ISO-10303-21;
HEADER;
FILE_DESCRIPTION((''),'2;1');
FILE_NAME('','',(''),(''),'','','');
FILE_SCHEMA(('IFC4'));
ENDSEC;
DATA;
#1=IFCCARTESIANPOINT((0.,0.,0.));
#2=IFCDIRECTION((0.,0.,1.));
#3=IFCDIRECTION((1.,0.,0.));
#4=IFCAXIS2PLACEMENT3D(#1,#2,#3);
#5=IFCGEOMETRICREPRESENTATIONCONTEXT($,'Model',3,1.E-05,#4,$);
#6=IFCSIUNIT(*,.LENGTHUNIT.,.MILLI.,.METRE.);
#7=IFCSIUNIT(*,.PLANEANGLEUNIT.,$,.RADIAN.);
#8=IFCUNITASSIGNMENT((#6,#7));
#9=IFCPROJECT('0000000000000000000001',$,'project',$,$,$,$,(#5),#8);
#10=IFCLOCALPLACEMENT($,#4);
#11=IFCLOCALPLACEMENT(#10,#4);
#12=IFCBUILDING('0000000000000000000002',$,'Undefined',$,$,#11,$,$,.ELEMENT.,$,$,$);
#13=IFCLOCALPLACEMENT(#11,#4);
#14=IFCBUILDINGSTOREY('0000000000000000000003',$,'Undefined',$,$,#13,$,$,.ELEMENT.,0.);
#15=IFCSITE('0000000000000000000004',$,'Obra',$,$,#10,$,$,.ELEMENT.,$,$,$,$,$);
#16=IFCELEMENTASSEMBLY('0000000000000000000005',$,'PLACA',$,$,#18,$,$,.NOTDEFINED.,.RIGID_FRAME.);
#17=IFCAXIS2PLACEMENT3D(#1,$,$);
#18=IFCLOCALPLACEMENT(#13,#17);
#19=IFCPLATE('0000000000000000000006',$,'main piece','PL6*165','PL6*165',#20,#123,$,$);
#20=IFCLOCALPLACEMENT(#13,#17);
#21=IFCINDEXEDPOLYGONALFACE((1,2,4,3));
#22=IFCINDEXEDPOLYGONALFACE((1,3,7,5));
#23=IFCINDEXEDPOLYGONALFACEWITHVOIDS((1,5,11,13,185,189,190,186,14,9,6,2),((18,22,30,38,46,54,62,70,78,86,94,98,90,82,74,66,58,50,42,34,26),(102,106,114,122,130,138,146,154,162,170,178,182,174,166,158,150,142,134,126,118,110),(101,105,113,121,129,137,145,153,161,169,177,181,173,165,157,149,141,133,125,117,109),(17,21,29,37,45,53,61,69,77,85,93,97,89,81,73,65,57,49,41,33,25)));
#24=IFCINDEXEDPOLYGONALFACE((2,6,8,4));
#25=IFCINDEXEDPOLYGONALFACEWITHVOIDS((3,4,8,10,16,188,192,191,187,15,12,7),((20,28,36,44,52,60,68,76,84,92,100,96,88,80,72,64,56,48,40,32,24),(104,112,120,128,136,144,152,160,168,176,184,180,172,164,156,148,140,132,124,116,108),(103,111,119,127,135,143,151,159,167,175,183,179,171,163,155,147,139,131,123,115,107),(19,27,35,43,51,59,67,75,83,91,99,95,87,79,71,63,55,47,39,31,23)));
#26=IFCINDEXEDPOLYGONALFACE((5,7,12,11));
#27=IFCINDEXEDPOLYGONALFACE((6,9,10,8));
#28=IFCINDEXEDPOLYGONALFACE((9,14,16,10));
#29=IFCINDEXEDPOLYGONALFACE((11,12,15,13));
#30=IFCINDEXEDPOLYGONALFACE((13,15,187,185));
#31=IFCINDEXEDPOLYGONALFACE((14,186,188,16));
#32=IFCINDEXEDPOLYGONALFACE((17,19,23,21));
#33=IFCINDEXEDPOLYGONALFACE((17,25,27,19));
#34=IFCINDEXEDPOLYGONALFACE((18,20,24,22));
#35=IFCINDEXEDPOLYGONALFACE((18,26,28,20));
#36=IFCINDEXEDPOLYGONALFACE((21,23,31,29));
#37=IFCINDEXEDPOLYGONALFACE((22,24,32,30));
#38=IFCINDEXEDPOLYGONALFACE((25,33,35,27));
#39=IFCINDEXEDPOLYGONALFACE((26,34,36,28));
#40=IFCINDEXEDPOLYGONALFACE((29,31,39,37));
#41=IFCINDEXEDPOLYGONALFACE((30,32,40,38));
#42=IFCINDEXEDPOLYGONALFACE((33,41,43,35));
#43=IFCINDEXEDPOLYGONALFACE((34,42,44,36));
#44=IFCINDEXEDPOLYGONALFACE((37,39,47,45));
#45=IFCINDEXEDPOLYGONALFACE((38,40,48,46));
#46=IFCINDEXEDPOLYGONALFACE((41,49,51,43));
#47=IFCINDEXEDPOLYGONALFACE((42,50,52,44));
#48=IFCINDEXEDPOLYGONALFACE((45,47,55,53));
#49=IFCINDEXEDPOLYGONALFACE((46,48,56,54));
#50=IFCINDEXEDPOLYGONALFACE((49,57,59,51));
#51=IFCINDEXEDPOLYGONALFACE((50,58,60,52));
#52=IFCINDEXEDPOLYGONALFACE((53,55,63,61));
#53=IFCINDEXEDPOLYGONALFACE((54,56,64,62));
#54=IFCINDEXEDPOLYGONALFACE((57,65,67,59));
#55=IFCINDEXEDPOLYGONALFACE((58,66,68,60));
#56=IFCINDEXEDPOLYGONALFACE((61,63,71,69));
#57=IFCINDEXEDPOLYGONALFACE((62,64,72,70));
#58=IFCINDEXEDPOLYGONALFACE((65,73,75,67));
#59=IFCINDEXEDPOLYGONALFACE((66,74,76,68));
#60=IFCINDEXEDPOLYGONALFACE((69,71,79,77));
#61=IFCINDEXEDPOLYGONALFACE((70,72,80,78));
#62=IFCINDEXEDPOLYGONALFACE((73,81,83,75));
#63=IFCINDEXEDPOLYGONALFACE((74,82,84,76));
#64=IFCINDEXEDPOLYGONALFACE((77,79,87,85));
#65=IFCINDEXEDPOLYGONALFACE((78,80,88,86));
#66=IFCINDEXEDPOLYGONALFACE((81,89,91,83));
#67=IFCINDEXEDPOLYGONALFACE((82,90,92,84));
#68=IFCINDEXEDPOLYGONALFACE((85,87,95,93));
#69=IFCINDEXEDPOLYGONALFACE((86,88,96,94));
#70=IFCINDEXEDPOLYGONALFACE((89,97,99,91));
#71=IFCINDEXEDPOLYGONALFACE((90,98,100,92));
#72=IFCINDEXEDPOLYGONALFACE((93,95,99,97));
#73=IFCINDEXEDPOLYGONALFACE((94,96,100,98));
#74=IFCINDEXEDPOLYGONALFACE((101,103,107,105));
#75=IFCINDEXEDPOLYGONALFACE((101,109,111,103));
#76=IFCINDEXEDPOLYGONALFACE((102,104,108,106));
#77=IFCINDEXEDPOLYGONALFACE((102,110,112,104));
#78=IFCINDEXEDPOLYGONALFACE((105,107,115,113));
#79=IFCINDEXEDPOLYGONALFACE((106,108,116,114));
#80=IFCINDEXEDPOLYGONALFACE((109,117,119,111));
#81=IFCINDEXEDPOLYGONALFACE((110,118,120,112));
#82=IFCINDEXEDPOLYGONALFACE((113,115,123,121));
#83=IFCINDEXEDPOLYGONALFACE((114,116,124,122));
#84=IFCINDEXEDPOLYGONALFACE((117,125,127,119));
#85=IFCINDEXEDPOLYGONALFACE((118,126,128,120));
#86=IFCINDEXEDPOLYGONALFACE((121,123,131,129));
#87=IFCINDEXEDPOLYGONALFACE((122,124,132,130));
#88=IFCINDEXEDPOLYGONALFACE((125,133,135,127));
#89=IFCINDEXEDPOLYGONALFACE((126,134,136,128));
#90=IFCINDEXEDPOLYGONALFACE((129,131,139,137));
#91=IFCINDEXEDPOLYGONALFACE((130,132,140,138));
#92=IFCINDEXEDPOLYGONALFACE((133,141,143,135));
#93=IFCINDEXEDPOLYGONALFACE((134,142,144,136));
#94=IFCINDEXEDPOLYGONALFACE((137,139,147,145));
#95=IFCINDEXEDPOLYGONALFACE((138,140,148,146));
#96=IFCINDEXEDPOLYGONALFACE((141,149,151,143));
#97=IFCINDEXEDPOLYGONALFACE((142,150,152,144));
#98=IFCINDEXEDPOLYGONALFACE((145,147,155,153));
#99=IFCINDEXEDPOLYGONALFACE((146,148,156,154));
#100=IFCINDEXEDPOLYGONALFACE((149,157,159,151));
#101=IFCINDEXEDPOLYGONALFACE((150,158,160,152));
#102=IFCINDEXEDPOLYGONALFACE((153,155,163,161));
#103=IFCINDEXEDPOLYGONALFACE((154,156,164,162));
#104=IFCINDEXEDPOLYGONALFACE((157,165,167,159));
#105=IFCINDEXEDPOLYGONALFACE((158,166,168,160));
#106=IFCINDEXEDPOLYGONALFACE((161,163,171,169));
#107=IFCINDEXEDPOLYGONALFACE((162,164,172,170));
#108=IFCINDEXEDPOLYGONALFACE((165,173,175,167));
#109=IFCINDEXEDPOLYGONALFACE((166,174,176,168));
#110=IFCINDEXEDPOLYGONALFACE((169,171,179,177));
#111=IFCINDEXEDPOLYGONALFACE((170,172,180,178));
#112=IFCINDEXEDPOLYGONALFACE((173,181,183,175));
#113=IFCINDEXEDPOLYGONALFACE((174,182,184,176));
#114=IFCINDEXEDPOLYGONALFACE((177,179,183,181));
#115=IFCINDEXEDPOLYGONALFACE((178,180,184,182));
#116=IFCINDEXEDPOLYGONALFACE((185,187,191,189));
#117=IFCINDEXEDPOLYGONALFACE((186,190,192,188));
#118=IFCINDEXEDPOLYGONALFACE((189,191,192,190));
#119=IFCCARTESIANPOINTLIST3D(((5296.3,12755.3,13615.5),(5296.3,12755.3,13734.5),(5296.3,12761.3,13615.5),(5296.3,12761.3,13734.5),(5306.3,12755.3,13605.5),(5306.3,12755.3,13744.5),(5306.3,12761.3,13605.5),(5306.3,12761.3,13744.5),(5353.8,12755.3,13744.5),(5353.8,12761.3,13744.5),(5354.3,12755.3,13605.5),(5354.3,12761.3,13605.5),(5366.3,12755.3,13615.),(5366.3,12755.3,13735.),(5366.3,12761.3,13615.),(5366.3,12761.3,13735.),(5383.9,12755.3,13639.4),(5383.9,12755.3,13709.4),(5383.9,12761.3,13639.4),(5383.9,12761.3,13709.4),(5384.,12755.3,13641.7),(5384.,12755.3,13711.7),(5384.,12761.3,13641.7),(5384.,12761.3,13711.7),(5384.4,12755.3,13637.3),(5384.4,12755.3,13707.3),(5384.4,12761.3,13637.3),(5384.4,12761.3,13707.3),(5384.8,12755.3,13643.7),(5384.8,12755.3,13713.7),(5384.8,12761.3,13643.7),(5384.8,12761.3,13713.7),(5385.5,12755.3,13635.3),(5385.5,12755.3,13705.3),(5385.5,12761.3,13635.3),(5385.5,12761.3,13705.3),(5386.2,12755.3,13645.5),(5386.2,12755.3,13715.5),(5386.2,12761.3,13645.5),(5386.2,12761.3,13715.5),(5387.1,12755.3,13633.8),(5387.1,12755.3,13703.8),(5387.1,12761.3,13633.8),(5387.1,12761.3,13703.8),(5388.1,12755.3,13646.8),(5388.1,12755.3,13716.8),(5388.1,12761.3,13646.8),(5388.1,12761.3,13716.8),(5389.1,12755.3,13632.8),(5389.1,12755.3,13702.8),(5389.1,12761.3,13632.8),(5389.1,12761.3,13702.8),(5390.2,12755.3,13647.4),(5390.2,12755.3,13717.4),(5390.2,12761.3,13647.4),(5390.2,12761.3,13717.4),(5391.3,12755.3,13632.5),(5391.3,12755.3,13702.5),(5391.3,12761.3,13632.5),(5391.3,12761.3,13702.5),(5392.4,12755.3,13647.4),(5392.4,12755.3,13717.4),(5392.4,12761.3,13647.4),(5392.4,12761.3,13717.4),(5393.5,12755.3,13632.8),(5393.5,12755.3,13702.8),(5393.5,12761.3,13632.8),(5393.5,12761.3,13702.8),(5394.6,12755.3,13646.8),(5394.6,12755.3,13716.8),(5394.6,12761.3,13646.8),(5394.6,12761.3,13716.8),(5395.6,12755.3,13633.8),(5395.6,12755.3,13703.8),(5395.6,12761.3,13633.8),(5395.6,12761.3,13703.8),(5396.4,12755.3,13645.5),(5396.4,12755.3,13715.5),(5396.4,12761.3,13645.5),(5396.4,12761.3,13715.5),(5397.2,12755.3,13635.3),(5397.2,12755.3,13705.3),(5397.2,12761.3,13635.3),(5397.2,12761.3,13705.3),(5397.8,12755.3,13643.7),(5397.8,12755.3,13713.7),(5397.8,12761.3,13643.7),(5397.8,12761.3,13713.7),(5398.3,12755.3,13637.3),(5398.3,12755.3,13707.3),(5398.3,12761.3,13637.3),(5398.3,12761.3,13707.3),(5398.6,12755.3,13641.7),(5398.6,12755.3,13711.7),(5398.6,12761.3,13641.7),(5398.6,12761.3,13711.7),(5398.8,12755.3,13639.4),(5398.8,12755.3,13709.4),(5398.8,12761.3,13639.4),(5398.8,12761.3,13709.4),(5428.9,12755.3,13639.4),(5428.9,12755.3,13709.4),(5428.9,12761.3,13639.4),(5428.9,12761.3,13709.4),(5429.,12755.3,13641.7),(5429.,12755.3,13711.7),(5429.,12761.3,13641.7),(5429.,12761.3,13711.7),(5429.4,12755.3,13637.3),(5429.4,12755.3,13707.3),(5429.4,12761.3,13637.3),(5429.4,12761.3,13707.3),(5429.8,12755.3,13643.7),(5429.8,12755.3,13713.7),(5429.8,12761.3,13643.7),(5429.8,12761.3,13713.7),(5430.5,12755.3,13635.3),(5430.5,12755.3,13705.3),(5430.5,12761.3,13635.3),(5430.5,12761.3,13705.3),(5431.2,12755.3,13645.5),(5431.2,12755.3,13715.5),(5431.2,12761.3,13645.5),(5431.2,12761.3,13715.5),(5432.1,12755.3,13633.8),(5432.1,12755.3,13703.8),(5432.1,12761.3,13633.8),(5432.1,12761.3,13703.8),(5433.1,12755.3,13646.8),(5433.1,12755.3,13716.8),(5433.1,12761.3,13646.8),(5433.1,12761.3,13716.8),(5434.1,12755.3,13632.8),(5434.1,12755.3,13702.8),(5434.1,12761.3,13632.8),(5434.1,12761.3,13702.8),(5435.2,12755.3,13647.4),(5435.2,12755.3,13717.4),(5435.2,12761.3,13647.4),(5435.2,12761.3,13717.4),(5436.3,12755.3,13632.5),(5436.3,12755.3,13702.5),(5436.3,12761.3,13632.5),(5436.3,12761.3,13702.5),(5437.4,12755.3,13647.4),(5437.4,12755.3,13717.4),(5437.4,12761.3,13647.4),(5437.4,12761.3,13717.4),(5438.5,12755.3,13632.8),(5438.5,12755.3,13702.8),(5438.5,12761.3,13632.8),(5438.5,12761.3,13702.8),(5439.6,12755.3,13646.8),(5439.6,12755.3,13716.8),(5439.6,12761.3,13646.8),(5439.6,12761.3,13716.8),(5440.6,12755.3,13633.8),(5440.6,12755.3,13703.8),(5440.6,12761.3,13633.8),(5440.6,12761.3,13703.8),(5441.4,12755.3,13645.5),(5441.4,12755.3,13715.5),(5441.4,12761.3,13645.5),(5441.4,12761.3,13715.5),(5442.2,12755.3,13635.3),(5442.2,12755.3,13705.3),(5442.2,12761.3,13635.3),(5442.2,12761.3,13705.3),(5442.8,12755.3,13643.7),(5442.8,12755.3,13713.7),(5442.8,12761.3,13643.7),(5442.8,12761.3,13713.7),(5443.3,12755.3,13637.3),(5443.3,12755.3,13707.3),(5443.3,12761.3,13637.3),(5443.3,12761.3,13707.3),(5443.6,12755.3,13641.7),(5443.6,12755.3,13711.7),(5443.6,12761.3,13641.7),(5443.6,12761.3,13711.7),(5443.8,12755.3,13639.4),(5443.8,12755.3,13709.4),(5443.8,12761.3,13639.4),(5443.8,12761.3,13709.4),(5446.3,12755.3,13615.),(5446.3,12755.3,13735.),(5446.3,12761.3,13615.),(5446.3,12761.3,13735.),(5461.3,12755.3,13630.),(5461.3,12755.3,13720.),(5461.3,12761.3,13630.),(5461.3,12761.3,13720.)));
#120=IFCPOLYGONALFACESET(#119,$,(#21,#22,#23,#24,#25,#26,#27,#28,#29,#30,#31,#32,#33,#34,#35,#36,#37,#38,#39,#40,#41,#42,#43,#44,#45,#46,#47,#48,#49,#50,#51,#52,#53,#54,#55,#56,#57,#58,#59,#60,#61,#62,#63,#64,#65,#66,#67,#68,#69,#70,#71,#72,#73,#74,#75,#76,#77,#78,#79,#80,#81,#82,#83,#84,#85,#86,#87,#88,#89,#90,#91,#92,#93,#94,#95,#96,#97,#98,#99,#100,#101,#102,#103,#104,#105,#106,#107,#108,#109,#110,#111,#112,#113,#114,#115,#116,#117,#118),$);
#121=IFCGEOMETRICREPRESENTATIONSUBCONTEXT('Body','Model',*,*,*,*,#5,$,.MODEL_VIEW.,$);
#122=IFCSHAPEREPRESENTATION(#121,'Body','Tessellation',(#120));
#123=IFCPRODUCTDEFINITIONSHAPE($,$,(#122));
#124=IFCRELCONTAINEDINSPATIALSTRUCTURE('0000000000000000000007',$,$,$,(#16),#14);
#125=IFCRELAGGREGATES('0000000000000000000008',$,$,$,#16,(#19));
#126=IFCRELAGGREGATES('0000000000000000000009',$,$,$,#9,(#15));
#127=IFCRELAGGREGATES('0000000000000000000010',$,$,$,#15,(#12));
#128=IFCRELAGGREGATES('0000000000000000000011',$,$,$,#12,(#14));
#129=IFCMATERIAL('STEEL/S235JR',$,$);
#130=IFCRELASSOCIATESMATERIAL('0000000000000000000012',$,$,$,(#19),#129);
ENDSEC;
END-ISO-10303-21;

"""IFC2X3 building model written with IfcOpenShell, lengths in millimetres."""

from ifc_helpers import new_model, si_unit, frame, origin_with_axes, origin_2d_with_axis, place, context, subcontext, project, spatial, polyline, circle, outline, extrude, source, transform, mapped, material, element, aggregate, save


model = new_model("IFC2X3")

# Units and contexts
model_context = context("Model", 3, precision=1e-05, world=origin_with_axes())
body_context = subcontext(model_context, "Body", "Model", "MODEL_VIEW")
ifc_project = project(units=[si_unit("LENGTHUNIT", "METRE", prefix="MILLI"), si_unit("PLANEANGLEUNIT", "RADIAN")], contexts=[model_context])

# Site, building, storey
site_placement = place(None, origin_with_axes())
site = spatial("IfcSite", under=ifc_project, at=site_placement, Name="Obra", CompositionType="ELEMENT")
building_placement = place(site_placement, origin_with_axes())
building = spatial("IfcBuilding", under=site, at=building_placement, Name="Undefined", CompositionType="ELEMENT")
storey_placement = place(building_placement, origin_with_axes())
storey = spatial("IfcBuildingStorey", under=building, at=storey_placement, Name="Undefined", CompositionType="ELEMENT", Elevation=0.0)

# Shared definitions
ifc_material_1 = material(Name="STEEL/S235JR")

# Element assembly, plate, opening
shared_shape_1 = source(origin_with_axes(), body_context, "Body", "SweptSolid", [
    extrude(circle(Radius=7.5, at=origin_2d_with_axis()), frame((0.0, 2.4, 0.0), z_axis=(0.0, 1.0, 0.0), x_axis=(1.0, 0.0, 0.0)), (0.0, 0.0, 1.0), 6.2),
])
assembly_1_placement = place(storey_placement, origin_with_axes())
assembly_1 = element("IfcElementAssembly", 1, at=assembly_1_placement, inside=storey, Name="PLACA", AssemblyPlace="NOTDEFINED", PredefinedType="RIGID_FRAME")
plate_1_placement = place(assembly_1_placement, frame((5296.3, 12758.3, 13615.5), z_axis=(0.0, -1.0, 0.0), x_axis=(0.707107, 0.0, -0.707107)))
plate_1 = element("IfcPlate", 2, at=plate_1_placement, material=ifc_material_1, Name="main piece", Description="PL6*165", ObjectType="PL6*165", context=body_context, shape_type="SweptSolid", body=[
    extrude(outline(polyline([(0.0, 0.0), (14.1, 0.0), (48.1, 33.9), (49.9, 49.1), (106.4, 105.7), (106.4, 126.9), (42.8, 190.6), (21.6, 190.6), (-35.0, 134.0), (-50.6, 131.9), (-84.1, 98.3), (-84.1, 84.1), (0.0, 0.0)])), frame((0.0, 0.0, -3.0), z_axis=(0.0, 0.0, 1.0), x_axis=(1.0, 0.0, 0.0)), (0.0, 0.0, 1.0), 6.0),
])
opening_1_placement = place(assembly_1_placement, frame((5413.8, 12752.8, 13710.0), z_axis=(1.0, 0.0, 0.0), x_axis=(0.0, 0.0, -1.0)))
element("IfcOpeningElement", 3, at=opening_1_placement, cuts=plate_1, ObjectType="Opening", context=body_context, shape_type="MappedRepresentation", body=[
    mapped(shared_shape_1, transform((0.0, 0.0, -22.5))),
    mapped(shared_shape_1, transform((70.0, 0.0, -22.5))),
    mapped(shared_shape_1, transform((0.0, 0.0, 22.5))),
    mapped(shared_shape_1, transform((70.0, 0.0, 22.5))),
])
aggregate(assembly_1, [plate_1])

save(model, "model.ifc")
